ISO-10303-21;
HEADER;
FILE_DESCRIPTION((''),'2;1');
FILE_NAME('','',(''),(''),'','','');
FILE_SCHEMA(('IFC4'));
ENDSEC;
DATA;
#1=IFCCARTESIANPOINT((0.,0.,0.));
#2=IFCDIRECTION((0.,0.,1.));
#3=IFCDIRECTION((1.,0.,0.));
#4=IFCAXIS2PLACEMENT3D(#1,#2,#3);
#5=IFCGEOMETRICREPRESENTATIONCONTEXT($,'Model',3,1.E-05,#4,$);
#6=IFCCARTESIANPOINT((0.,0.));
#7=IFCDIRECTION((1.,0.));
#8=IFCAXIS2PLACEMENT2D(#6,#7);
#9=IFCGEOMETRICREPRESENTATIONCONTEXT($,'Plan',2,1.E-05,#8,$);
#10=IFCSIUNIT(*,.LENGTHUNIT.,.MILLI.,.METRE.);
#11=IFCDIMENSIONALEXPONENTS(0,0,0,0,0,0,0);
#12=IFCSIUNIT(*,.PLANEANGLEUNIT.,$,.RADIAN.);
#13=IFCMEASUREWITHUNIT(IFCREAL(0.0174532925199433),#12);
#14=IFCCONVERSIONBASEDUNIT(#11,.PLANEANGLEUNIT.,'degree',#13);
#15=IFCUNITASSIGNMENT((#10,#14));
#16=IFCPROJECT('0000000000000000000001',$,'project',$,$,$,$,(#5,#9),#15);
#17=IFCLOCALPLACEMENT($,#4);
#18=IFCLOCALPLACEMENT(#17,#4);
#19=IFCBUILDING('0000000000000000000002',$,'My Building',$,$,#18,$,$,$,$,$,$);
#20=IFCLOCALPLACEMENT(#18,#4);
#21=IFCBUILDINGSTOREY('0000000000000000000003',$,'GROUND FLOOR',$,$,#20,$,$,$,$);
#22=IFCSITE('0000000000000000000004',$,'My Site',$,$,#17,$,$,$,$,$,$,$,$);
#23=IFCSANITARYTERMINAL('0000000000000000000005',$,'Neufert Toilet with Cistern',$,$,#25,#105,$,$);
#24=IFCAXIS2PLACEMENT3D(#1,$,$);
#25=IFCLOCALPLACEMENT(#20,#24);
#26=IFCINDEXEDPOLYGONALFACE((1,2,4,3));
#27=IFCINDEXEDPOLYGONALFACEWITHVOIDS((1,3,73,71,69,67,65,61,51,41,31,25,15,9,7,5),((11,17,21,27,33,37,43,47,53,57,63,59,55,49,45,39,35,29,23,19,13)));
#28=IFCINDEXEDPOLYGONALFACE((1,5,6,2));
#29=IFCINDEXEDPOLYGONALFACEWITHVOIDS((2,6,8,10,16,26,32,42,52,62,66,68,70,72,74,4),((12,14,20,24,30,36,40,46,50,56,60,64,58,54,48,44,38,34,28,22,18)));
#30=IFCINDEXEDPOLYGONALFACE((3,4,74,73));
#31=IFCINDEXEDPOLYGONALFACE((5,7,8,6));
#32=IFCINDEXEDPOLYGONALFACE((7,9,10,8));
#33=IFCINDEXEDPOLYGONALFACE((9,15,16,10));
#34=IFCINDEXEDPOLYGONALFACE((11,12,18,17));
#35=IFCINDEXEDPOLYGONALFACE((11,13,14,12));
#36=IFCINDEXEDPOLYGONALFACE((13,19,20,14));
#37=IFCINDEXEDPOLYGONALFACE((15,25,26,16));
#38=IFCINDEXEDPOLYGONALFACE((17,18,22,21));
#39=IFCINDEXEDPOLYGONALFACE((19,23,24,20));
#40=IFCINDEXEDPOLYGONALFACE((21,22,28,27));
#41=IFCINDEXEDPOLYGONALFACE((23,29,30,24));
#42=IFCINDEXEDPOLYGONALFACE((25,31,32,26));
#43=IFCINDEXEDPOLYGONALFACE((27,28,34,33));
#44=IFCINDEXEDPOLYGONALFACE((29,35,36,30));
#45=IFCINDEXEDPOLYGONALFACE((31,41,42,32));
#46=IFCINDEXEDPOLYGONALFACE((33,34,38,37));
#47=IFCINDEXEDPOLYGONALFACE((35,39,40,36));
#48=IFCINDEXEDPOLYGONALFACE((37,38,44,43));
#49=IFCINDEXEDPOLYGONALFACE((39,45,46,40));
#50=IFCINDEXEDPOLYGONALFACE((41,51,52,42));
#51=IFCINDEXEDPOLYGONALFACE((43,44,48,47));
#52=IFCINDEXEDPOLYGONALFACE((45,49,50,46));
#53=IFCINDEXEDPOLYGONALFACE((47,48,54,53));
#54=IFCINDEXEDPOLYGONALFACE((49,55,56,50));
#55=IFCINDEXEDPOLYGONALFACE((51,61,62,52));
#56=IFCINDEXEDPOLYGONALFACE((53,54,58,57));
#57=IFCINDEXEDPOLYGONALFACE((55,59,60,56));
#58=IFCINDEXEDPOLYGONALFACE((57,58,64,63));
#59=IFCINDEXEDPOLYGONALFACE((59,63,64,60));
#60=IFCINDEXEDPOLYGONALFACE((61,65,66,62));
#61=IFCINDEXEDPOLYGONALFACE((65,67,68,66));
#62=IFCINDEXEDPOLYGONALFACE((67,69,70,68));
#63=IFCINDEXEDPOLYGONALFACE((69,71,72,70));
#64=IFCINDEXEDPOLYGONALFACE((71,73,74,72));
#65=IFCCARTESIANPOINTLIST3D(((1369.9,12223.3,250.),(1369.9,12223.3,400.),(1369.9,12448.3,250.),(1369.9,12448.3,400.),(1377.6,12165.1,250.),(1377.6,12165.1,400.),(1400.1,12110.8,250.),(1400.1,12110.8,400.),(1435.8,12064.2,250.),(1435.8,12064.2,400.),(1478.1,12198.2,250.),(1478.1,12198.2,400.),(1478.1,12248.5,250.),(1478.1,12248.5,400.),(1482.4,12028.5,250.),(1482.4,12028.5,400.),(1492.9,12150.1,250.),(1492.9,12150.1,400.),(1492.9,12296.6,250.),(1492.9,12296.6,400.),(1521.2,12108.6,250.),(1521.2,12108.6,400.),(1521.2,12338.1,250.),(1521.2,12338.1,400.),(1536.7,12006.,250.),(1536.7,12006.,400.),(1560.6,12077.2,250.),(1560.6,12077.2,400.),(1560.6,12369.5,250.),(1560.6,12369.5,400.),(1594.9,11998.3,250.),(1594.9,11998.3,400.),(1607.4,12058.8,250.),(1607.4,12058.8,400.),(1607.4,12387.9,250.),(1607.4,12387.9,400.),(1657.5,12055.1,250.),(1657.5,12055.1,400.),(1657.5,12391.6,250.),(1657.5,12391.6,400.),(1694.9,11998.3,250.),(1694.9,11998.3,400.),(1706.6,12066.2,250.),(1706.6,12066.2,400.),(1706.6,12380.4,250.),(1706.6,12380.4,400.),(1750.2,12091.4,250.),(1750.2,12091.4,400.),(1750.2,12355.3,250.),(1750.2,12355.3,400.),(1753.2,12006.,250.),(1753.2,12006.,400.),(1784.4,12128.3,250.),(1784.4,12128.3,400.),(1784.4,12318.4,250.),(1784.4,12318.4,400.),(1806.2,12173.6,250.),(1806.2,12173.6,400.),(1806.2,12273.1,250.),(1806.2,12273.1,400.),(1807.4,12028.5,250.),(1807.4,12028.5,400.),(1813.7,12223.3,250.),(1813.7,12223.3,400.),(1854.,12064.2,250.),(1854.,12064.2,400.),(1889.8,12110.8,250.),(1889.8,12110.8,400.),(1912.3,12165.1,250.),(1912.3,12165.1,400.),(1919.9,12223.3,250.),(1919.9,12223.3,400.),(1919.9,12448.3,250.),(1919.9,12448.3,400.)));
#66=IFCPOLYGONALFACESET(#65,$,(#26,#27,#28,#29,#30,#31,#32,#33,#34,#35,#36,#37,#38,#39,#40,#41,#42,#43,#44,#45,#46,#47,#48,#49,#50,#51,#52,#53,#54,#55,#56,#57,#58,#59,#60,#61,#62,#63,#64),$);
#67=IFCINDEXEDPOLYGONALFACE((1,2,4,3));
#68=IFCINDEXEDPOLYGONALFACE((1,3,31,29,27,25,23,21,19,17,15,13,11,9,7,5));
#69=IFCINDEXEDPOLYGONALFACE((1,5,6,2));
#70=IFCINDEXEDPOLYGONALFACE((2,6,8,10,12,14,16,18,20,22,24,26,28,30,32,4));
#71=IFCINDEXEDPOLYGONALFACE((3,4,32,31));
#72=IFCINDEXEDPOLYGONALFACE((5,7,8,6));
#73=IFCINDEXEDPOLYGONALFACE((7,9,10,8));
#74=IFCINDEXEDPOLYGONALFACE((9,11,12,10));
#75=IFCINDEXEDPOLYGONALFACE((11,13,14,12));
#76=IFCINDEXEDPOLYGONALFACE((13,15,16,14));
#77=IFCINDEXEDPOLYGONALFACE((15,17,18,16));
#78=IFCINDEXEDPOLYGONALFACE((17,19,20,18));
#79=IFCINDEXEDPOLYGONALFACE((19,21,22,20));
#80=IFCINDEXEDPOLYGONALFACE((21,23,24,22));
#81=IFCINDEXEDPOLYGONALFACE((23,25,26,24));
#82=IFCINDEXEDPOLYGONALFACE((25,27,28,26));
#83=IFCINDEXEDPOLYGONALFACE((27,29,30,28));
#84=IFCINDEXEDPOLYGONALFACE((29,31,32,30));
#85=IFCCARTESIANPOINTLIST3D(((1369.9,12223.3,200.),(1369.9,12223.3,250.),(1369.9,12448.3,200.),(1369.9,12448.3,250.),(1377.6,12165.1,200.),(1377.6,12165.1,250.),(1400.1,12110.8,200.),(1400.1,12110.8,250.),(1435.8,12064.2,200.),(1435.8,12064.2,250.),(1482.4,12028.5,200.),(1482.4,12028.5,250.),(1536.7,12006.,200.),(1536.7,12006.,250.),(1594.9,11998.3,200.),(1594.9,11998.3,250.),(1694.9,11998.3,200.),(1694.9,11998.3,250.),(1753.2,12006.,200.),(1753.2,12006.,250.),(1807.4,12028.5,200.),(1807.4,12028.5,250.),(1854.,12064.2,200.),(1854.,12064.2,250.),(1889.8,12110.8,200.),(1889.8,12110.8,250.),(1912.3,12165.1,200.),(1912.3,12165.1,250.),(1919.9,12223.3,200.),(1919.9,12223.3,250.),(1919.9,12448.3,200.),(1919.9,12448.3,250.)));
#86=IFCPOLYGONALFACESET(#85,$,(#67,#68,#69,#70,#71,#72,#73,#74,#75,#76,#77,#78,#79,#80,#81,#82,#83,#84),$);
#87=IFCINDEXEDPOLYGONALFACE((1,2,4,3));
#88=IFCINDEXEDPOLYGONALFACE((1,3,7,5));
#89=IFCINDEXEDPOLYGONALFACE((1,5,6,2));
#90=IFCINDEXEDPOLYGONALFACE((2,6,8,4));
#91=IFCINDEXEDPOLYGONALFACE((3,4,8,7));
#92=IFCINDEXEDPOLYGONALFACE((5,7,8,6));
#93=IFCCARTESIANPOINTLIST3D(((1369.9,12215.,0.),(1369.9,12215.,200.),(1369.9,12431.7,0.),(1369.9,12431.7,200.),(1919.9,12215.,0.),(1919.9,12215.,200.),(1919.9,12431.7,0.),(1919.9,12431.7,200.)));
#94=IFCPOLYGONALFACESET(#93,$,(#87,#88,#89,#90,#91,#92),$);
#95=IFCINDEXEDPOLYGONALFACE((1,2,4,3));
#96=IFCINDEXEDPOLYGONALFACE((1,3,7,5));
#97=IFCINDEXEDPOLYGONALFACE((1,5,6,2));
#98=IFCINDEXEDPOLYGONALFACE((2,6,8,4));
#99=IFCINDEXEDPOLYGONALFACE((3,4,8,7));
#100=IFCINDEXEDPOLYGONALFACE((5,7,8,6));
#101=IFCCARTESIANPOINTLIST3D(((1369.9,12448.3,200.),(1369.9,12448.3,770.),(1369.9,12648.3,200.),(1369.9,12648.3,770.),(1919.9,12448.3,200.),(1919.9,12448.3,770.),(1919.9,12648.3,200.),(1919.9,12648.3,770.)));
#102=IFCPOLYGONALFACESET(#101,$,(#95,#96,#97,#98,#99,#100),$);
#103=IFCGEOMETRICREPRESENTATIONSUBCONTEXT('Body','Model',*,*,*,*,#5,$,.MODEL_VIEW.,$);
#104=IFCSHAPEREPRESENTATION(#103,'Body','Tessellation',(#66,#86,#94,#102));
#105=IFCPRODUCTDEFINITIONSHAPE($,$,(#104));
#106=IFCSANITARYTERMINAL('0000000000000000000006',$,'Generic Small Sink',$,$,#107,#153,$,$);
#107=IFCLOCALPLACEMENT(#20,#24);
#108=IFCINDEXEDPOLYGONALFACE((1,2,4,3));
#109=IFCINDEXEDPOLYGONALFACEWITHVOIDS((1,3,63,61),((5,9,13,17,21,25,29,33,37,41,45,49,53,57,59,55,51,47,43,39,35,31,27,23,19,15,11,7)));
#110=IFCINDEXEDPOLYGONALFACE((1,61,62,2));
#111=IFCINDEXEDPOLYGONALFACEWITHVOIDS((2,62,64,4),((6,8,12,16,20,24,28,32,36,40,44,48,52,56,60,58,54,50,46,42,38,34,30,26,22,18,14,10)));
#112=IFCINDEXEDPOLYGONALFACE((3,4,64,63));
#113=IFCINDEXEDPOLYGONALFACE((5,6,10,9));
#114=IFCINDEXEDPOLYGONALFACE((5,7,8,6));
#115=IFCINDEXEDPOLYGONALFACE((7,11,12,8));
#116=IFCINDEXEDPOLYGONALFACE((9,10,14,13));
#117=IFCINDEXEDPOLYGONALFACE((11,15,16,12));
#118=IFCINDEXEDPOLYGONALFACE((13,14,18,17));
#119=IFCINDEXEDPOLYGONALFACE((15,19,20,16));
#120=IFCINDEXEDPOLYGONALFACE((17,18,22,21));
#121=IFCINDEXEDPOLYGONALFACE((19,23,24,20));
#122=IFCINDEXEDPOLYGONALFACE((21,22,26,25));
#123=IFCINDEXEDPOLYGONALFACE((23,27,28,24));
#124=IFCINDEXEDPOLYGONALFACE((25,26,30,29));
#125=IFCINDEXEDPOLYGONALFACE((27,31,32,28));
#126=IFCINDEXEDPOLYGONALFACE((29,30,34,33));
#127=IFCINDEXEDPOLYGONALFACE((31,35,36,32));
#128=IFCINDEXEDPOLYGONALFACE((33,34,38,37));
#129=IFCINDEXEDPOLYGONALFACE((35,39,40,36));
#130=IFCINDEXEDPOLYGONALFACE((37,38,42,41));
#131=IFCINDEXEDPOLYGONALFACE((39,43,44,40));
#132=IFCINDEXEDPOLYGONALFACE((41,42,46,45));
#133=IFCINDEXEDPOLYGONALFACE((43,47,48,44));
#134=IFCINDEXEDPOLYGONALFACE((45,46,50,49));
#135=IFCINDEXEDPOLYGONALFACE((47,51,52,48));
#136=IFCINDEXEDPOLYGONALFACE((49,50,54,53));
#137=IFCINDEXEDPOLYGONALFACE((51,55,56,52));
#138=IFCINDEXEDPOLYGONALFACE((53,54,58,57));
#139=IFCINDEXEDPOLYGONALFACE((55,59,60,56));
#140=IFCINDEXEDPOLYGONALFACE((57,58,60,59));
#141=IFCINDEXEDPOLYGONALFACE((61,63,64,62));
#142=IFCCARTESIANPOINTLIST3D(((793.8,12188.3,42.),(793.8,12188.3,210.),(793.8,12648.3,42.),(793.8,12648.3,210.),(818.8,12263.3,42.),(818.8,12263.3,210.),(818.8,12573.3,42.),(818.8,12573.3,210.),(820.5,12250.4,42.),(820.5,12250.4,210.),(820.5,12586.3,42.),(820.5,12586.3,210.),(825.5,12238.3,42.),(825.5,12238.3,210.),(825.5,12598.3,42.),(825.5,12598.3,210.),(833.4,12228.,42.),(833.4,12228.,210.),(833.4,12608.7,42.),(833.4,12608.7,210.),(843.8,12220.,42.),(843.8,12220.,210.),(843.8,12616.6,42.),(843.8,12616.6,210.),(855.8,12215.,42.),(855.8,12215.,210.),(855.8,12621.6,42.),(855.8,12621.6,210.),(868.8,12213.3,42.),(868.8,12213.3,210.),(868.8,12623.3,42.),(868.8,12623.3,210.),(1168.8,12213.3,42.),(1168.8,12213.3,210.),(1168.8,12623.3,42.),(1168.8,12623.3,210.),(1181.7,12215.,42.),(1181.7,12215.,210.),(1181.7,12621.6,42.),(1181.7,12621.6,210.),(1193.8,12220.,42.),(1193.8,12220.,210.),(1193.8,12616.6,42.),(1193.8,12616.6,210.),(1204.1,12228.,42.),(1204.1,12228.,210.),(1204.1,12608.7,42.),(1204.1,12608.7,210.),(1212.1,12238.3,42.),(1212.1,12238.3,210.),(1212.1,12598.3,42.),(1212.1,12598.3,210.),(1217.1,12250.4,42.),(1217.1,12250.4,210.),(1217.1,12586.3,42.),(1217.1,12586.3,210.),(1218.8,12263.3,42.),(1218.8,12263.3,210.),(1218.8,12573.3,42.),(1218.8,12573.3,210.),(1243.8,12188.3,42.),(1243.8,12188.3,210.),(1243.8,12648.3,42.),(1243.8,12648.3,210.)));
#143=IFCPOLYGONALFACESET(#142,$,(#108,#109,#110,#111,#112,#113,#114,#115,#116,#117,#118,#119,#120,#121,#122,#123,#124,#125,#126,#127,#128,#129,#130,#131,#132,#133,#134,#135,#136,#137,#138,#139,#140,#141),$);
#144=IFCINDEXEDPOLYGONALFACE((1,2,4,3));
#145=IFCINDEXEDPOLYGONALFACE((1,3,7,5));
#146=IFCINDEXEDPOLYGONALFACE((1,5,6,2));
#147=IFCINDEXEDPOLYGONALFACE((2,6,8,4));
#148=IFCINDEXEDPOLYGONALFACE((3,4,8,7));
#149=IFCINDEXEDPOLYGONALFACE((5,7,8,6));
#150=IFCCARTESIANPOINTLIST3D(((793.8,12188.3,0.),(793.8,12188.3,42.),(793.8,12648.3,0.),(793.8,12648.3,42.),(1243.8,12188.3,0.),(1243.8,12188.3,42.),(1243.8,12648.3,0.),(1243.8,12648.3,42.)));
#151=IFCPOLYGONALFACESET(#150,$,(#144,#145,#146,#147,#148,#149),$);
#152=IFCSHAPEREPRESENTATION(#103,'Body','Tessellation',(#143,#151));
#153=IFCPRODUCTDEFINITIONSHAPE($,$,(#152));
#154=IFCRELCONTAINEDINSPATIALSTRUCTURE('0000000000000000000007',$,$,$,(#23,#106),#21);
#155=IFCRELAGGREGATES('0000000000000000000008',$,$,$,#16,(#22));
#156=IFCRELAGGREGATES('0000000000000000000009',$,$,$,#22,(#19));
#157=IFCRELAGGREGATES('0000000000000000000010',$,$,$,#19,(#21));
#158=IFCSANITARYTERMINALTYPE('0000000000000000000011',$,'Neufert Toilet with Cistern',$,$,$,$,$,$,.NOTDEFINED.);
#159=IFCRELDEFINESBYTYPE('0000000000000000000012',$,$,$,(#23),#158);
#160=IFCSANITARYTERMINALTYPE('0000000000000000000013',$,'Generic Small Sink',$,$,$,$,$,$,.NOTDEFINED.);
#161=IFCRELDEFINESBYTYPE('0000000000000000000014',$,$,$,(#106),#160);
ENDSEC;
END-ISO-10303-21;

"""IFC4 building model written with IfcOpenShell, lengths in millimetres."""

from ifc_helpers import new_model, entity, si_unit, converted_unit, frame, frame_2d, origin_with_axes, origin_2d_with_axis, place, context, subcontext, project, spatial, line, arc, indexed_curve, circle_curve, outline, extrude, shape, source, transform, mapped, type_object, type_shapes, element, save


model = new_model("IFC4")

# Units and contexts
model_context = context("Model", 3, precision=1e-05, world=origin_with_axes())
plan_context = context("Plan", 2, precision=1e-05, world=origin_2d_with_axis())
body_context_1 = subcontext(model_context, "Body", "Model", "MODEL_VIEW")
body_context_2 = subcontext(plan_context, "Body", "Plan", "PLAN_VIEW")
ifc_project = project(units=[si_unit("LENGTHUNIT", "METRE", prefix="MILLI"), converted_unit("PLANEANGLEUNIT", "degree", entity("IfcReal", 0.0174532925199433), si_unit("PLANEANGLEUNIT", "RADIAN"), dimensions=[0, 0, 0, 0, 0, 0, 0])], contexts=[model_context, plan_context])

# Site, building, storey
site_placement = place(None, origin_with_axes())
site = spatial("IfcSite", under=ifc_project, at=site_placement, Name="My Site")
building_placement = place(site_placement, origin_with_axes())
building = spatial("IfcBuilding", under=site, at=building_placement, Name="My Building")
storey_placement = place(building_placement, origin_with_axes())
storey = spatial("IfcBuildingStorey", under=building, at=storey_placement, Name="GROUND FLOOR")

# Sanitary terminals
sanitary_terminal_type_1 = type_object("IfcSanitaryTerminalType", Name="Neufert Toilet with Cistern", PredefinedType="NOTDEFINED")
shared_shape_1 = source(origin_with_axes(), body_context_1, "Body", "SweptSolid", [
    extrude(outline(indexed_curve([(-275.0, -200.0), (275.0, -200.0), (275.0, -425.0), (209.1, -584.1), (50.0, -650.0), (-50.0, -650.0), (-209.1, -584.1), (-275.0, -425.0)], segments=[line(1, 2), line(2, 3), arc(3, 4, 5), line(5, 6), arc(6, 7, 8), line(8, 1)]), holes=[circle_curve(frame_2d((0.0, -425.0)), 168.8)]), frame((0.0, 0.0, 250.0), z_axis=(0.0, 0.0, 1.0), x_axis=(1.0, 0.0, 0.0)), (0.0, 0.0, 1.0), 150.0),
    extrude(outline(indexed_curve([(-275.0, -200.0), (275.0, -200.0), (275.0, -425.0), (209.1, -584.1), (50.0, -650.0), (-50.0, -650.0), (-209.1, -584.1), (-275.0, -425.0)], segments=[line(1, 2), line(2, 3), arc(3, 4, 5), line(5, 6), arc(6, 7, 8), line(8, 1)])), frame((0.0, 0.0, 200.0), z_axis=(0.0, 0.0, 1.0), x_axis=(1.0, 0.0, 0.0)), (0.0, 0.0, 1.0), 50.0),
    extrude(outline(indexed_curve([(-275.0, -216.7), (275.0, -216.7), (275.0, -433.3), (-275.0, -433.3)], segments=[line(1, 2, 3, 4, 1)])), origin_with_axes(), (0.0, 0.0, 1.0), 200.0),
    extrude(outline(indexed_curve([(-275.0, 0.0), (275.0, 0.0), (275.0, -200.0), (-275.0, -200.0)], segments=[line(1, 2, 3, 4, 1)])), frame((0.0, 0.0, 200.0), z_axis=(0.0, 0.0, 1.0), x_axis=(1.0, 0.0, 0.0)), (0.0, 0.0, 1.0), 570.0),
])
shared_shape_2 = source(origin_with_axes(), body_context_2, "Body", "Curve2D", [
    entity("IfcIndexedPolyCurve", entity("IfcCartesianPointList2D", [[-275.0, 0.0], [275.0, 0.0], [275.0, -200.0], [-275.0, -200.0]]), [entity("IfcLineIndex", [1, 2, 3, 4, 1])]),
    entity("IfcIndexedPolyCurve", entity("IfcCartesianPointList2D", [[165.0, -200.0], [192.5, -335.0]])),
    entity("IfcTrimmedCurve", entity("IfcEllipse", entity("IfcAxis2Placement2D", entity("IfcCartesianPoint", [0.0, -335.0]), entity("IfcDirection", [1.0, 0.0])), 192.5, 315.0), [entity("IfcCartesianPoint", [-192.5, -335.0])], [entity("IfcCartesianPoint", [192.5, -335.0])], True, "CARTESIAN"),
    entity("IfcIndexedPolyCurve", entity("IfcCartesianPointList2D", [[-165.0, -200.0], [-192.5, -335.0]])),
    entity("IfcEllipse", entity("IfcAxis2Placement2D", entity("IfcCartesianPoint", [0.0, -452.0]), entity("IfcDirection", [1.0, 0.0])), 131.2, 157.5),
    entity("IfcIndexedPolyCurve", entity("IfcCartesianPointList2D", [[-34.4, -452.0], [-34.4, -429.5], [34.4, -429.5], [34.4, -452.0]])),
    entity("IfcTrimmedCurve", entity("IfcEllipse", entity("IfcAxis2Placement2D", entity("IfcCartesianPoint", [0.0, -452.0]), entity("IfcDirection", [1.0, 0.0])), 34.4, 22.5), [entity("IfcCartesianPoint", [-34.4, -452.0])], [entity("IfcCartesianPoint", [34.4, -452.0])], True, "CARTESIAN"),
])
type_shapes(sanitary_terminal_type_1, [shared_shape_1, shared_shape_2])
sanitary_terminal_1_placement = place(storey_placement, frame((1644.9, 12648.3, 0.0), z_axis=(0.0, 0.0, 1.0), x_axis=(1.0, 0.0, 0.0)))
element("IfcSanitaryTerminal", 1, at=sanitary_terminal_1_placement, inside=storey, type_object=sanitary_terminal_type_1, Name="Neufert Toilet with Cistern", shapes=[
    shape(body_context_1, "Body", "MappedRepresentation", [mapped(shared_shape_1, transform((0.0, 0.0, 0.0), x_axis=(1.0, 0.0, 0.0), y_axis=(0.0, 1.0, 0.0), z_axis=(0.0, 0.0, 1.0), scale=1.0))]),
    shape(body_context_2, "Body", "MappedRepresentation", [mapped(shared_shape_2, transform((0.0, 0.0, 0.0), x_axis=(1.0, 0.0, 0.0), y_axis=(0.0, 1.0, 0.0), z_axis=(0.0, 0.0, 1.0), scale=1.0))]),
])
sanitary_terminal_type_2 = type_object("IfcSanitaryTerminalType", Name="Generic Small Sink", PredefinedType="NOTDEFINED")
shared_indexed_poly_curve = entity("IfcIndexedPolyCurve", entity("IfcCartesianPointList2D", [[0.0, 0.0], [450.0, 0.0], [450.0, 460.0], [0.0, 460.0]]), [entity("IfcLineIndex", [1, 2, 3, 4, 1])])
shared_shape_3 = source(origin_with_axes(), body_context_1, "Body", "SweptSolid", [
    entity("IfcExtrudedAreaSolid", entity("IfcArbitraryProfileDefWithVoids", "AREA", None, shared_indexed_poly_curve, [entity("IfcIndexedPolyCurve", entity("IfcCartesianPointList2D", [[25.0, 75.0], [39.6, 39.6], [75.0, 25.0], [375.0, 25.0], [410.4, 39.6], [425.0, 75.0], [425.0, 385.0], [410.4, 420.4], [375.0, 435.0], [75.0, 435.0], [39.6, 420.4], [25.0, 385.0]]), [entity("IfcLineIndex", [12, 1]), entity("IfcArcIndex", [1, 2, 3]), entity("IfcLineIndex", [3, 4]), entity("IfcArcIndex", [4, 5, 6]), entity("IfcLineIndex", [6, 7]), entity("IfcArcIndex", [7, 8, 9]), entity("IfcLineIndex", [9, 10]), entity("IfcArcIndex", [10, 11, 12]), entity("IfcLineIndex", [12, 1])])]), entity("IfcAxis2Placement3D", entity("IfcCartesianPoint", [-225.0, -460.0, 42.0]), entity("IfcDirection", [0.0, 0.0, 1.0]), entity("IfcDirection", [1.0, 0.0, 0.0])), entity("IfcDirection", [0.0, 0.0, 1.0]), 168.0),
    entity("IfcExtrudedAreaSolid", entity("IfcArbitraryClosedProfileDef", "AREA", None, shared_indexed_poly_curve), entity("IfcAxis2Placement3D", entity("IfcCartesianPoint", [-225.0, -460.0, 0.0]), entity("IfcDirection", [0.0, 0.0, 1.0]), entity("IfcDirection", [1.0, 0.0, 0.0])), entity("IfcDirection", [0.0, 0.0, 1.0]), 42.0),
])
shared_shape_4 = source(origin_with_axes(), body_context_2, "Body", "Curve2D", [
    entity("IfcIndexedPolyCurve", entity("IfcCartesianPointList2D", [[-225.0, -460.0], [225.0, -460.0], [225.0, 0.0], [-225.0, 0.0]]), [entity("IfcLineIndex", [1, 2, 3, 4, 1])]),
    entity("IfcIndexedPolyCurve", entity("IfcCartesianPointList2D", [[-200.0, -385.0], [-185.4, -420.4], [-150.0, -435.0], [150.0, -435.0], [185.4, -420.4], [200.0, -385.0], [200.0, -75.0], [185.4, -39.6], [150.0, -25.0], [-150.0, -25.0], [-185.4, -39.6], [-200.0, -75.0]]), [entity("IfcLineIndex", [12, 1]), entity("IfcArcIndex", [1, 2, 3]), entity("IfcLineIndex", [3, 4]), entity("IfcArcIndex", [4, 5, 6]), entity("IfcLineIndex", [6, 7]), entity("IfcArcIndex", [7, 8, 9]), entity("IfcLineIndex", [9, 10]), entity("IfcArcIndex", [10, 11, 12]), entity("IfcLineIndex", [12, 1])]),
    entity("IfcCircle", entity("IfcAxis2Placement2D", entity("IfcCartesianPoint", [0.0, -125.0])), 25.0),
    entity("IfcIndexedPolyCurve", entity("IfcCartesianPointList2D", [[0.0, -12.5], [0.0, -132.5]])),
])
type_shapes(sanitary_terminal_type_2, [shared_shape_3, shared_shape_4])
sanitary_terminal_2_placement = place(storey_placement, frame((1018.8, 12648.3, 0.0), z_axis=(0.0, 0.0, 1.0), x_axis=(1.0, 0.0, 0.0)))
element("IfcSanitaryTerminal", 2, at=sanitary_terminal_2_placement, inside=storey, type_object=sanitary_terminal_type_2, Name="Generic Small Sink", shapes=[
    shape(body_context_1, "Body", "MappedRepresentation", [mapped(shared_shape_3, transform((0.0, 0.0, 0.0), x_axis=(1.0, 0.0, 0.0), y_axis=(0.0, 1.0, 0.0), z_axis=(0.0, 0.0, 1.0), scale=1.0))]),
    shape(body_context_2, "Body", "MappedRepresentation", [mapped(shared_shape_4, transform((0.0, 0.0, 0.0), x_axis=(1.0, 0.0, 0.0), y_axis=(0.0, 1.0, 0.0), z_axis=(0.0, 0.0, 1.0), scale=1.0))]),
])

save(model, "model.ifc")
